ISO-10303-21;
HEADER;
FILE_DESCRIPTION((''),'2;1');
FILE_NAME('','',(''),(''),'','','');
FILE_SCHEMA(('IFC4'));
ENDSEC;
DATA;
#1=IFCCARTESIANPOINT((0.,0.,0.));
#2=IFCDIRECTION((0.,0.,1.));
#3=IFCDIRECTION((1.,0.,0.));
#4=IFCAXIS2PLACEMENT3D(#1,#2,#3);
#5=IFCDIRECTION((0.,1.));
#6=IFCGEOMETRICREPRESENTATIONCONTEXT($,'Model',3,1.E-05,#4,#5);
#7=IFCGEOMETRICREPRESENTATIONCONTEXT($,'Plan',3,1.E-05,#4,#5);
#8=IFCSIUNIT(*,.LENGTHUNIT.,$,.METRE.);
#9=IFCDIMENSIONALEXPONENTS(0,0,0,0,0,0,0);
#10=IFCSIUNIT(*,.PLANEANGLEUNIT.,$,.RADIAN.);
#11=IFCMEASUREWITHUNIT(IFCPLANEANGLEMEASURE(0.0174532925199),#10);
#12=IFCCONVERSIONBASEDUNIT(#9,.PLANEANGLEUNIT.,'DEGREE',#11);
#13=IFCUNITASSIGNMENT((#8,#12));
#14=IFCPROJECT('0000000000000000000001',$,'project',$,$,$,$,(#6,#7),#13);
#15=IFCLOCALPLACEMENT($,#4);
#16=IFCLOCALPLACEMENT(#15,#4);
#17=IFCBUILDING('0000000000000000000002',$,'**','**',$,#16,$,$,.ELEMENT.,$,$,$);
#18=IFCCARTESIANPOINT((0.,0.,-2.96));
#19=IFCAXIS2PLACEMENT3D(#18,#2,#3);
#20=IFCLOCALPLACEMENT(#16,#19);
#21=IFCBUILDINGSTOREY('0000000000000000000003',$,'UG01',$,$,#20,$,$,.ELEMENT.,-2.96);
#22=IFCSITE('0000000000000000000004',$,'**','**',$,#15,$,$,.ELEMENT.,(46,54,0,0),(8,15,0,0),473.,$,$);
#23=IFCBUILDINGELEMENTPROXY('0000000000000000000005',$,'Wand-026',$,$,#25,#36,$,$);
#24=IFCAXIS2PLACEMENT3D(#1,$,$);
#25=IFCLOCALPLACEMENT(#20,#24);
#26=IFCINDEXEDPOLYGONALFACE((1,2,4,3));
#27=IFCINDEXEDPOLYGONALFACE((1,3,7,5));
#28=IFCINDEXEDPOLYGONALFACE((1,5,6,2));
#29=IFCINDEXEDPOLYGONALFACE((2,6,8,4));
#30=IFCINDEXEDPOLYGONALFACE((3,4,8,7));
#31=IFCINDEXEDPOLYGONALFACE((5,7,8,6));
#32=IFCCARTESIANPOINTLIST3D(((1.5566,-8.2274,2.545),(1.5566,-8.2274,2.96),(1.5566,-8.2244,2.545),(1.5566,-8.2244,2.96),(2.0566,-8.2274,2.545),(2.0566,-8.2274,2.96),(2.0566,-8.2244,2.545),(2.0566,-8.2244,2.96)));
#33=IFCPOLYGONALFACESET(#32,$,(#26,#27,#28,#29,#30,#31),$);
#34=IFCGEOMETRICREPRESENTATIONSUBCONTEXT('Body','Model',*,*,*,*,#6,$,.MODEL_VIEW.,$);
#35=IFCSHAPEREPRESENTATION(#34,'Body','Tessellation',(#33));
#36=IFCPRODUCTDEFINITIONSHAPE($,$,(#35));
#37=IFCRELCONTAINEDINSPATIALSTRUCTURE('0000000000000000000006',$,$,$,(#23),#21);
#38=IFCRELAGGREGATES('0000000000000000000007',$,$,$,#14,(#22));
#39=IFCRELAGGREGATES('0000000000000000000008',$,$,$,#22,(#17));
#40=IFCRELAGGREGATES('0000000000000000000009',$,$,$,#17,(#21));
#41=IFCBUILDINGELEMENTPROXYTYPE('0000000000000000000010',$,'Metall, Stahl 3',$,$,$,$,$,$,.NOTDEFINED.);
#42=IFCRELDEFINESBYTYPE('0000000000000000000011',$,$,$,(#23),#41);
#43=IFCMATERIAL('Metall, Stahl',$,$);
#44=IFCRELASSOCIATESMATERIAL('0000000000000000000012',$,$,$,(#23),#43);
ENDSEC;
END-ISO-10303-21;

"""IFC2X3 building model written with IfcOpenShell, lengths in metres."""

from ifc_helpers import new_model, entity, si_unit, converted_unit, direction, frame, origin_with_axes, place, context, subcontext, project, spatial, polyline, outline, extrude, material, type_object, element, save


model = new_model("IFC2X3")

# Units and contexts
model_context = context("Model", 3, precision=1e-05, world=origin_with_axes(), true_north=direction((0.0, 1.0)))
plan_context = context("Plan", 3, precision=1e-05, world=origin_with_axes(), true_north=direction((0.0, 1.0)))
body_context = subcontext(model_context, "Body", "Model", "MODEL_VIEW")
ifc_project = project(units=[si_unit("LENGTHUNIT", "METRE"), converted_unit("PLANEANGLEUNIT", "DEGREE", entity("IfcPlaneAngleMeasure", 0.0174532925199), si_unit("PLANEANGLEUNIT", "RADIAN"), dimensions=[0, 0, 0, 0, 0, 0, 0])], contexts=[model_context, plan_context])

# Site, building, storey
site_placement = place(None, origin_with_axes())
site = spatial("IfcSite", under=ifc_project, at=site_placement, Name="**", Description="**", CompositionType="ELEMENT", RefLatitude=(46, 54, 0, 0), RefLongitude=(8, 15, 0, 0), RefElevation=473.0)
building_placement = place(site_placement, origin_with_axes())
building = spatial("IfcBuilding", under=site, at=building_placement, Name="**", Description="**", CompositionType="ELEMENT")
storey_placement = place(building_placement, frame((0.0, 0.0, -2.96), z_axis=(0.0, 0.0, 1.0), x_axis=(1.0, 0.0, 0.0)))
storey = spatial("IfcBuildingStorey", under=building, at=storey_placement, Name="UG01", CompositionType="ELEMENT", Elevation=-2.96)

# Building element proxy
ifc_material = material(Name="Metall, Stahl")
building_element_proxy_type = type_object("IfcBuildingElementProxyType", Name="Metall, Stahl 3", PredefinedType="NOTDEFINED")
proxy_placement = place(storey_placement, frame((1.5566, -8.2274, 2.545), z_axis=(0.0, 0.0, 1.0), x_axis=(1.0, 0.0, 0.0)))
element("IfcBuildingElementProxy", 1, at=proxy_placement, inside=storey, type_object=building_element_proxy_type, material=ifc_material, Name="Wand-026", context=body_context, shape_type="SweptSolid", body=[
    extrude(outline(polyline([(0.0, 0.0), (0.5, 0.0), (0.5, 0.003), (0.0, 0.003), (0.0, 0.0)])), origin_with_axes(), (0.0, 0.0, 1.0), 0.415),
])

save(model, "model.ifc")
